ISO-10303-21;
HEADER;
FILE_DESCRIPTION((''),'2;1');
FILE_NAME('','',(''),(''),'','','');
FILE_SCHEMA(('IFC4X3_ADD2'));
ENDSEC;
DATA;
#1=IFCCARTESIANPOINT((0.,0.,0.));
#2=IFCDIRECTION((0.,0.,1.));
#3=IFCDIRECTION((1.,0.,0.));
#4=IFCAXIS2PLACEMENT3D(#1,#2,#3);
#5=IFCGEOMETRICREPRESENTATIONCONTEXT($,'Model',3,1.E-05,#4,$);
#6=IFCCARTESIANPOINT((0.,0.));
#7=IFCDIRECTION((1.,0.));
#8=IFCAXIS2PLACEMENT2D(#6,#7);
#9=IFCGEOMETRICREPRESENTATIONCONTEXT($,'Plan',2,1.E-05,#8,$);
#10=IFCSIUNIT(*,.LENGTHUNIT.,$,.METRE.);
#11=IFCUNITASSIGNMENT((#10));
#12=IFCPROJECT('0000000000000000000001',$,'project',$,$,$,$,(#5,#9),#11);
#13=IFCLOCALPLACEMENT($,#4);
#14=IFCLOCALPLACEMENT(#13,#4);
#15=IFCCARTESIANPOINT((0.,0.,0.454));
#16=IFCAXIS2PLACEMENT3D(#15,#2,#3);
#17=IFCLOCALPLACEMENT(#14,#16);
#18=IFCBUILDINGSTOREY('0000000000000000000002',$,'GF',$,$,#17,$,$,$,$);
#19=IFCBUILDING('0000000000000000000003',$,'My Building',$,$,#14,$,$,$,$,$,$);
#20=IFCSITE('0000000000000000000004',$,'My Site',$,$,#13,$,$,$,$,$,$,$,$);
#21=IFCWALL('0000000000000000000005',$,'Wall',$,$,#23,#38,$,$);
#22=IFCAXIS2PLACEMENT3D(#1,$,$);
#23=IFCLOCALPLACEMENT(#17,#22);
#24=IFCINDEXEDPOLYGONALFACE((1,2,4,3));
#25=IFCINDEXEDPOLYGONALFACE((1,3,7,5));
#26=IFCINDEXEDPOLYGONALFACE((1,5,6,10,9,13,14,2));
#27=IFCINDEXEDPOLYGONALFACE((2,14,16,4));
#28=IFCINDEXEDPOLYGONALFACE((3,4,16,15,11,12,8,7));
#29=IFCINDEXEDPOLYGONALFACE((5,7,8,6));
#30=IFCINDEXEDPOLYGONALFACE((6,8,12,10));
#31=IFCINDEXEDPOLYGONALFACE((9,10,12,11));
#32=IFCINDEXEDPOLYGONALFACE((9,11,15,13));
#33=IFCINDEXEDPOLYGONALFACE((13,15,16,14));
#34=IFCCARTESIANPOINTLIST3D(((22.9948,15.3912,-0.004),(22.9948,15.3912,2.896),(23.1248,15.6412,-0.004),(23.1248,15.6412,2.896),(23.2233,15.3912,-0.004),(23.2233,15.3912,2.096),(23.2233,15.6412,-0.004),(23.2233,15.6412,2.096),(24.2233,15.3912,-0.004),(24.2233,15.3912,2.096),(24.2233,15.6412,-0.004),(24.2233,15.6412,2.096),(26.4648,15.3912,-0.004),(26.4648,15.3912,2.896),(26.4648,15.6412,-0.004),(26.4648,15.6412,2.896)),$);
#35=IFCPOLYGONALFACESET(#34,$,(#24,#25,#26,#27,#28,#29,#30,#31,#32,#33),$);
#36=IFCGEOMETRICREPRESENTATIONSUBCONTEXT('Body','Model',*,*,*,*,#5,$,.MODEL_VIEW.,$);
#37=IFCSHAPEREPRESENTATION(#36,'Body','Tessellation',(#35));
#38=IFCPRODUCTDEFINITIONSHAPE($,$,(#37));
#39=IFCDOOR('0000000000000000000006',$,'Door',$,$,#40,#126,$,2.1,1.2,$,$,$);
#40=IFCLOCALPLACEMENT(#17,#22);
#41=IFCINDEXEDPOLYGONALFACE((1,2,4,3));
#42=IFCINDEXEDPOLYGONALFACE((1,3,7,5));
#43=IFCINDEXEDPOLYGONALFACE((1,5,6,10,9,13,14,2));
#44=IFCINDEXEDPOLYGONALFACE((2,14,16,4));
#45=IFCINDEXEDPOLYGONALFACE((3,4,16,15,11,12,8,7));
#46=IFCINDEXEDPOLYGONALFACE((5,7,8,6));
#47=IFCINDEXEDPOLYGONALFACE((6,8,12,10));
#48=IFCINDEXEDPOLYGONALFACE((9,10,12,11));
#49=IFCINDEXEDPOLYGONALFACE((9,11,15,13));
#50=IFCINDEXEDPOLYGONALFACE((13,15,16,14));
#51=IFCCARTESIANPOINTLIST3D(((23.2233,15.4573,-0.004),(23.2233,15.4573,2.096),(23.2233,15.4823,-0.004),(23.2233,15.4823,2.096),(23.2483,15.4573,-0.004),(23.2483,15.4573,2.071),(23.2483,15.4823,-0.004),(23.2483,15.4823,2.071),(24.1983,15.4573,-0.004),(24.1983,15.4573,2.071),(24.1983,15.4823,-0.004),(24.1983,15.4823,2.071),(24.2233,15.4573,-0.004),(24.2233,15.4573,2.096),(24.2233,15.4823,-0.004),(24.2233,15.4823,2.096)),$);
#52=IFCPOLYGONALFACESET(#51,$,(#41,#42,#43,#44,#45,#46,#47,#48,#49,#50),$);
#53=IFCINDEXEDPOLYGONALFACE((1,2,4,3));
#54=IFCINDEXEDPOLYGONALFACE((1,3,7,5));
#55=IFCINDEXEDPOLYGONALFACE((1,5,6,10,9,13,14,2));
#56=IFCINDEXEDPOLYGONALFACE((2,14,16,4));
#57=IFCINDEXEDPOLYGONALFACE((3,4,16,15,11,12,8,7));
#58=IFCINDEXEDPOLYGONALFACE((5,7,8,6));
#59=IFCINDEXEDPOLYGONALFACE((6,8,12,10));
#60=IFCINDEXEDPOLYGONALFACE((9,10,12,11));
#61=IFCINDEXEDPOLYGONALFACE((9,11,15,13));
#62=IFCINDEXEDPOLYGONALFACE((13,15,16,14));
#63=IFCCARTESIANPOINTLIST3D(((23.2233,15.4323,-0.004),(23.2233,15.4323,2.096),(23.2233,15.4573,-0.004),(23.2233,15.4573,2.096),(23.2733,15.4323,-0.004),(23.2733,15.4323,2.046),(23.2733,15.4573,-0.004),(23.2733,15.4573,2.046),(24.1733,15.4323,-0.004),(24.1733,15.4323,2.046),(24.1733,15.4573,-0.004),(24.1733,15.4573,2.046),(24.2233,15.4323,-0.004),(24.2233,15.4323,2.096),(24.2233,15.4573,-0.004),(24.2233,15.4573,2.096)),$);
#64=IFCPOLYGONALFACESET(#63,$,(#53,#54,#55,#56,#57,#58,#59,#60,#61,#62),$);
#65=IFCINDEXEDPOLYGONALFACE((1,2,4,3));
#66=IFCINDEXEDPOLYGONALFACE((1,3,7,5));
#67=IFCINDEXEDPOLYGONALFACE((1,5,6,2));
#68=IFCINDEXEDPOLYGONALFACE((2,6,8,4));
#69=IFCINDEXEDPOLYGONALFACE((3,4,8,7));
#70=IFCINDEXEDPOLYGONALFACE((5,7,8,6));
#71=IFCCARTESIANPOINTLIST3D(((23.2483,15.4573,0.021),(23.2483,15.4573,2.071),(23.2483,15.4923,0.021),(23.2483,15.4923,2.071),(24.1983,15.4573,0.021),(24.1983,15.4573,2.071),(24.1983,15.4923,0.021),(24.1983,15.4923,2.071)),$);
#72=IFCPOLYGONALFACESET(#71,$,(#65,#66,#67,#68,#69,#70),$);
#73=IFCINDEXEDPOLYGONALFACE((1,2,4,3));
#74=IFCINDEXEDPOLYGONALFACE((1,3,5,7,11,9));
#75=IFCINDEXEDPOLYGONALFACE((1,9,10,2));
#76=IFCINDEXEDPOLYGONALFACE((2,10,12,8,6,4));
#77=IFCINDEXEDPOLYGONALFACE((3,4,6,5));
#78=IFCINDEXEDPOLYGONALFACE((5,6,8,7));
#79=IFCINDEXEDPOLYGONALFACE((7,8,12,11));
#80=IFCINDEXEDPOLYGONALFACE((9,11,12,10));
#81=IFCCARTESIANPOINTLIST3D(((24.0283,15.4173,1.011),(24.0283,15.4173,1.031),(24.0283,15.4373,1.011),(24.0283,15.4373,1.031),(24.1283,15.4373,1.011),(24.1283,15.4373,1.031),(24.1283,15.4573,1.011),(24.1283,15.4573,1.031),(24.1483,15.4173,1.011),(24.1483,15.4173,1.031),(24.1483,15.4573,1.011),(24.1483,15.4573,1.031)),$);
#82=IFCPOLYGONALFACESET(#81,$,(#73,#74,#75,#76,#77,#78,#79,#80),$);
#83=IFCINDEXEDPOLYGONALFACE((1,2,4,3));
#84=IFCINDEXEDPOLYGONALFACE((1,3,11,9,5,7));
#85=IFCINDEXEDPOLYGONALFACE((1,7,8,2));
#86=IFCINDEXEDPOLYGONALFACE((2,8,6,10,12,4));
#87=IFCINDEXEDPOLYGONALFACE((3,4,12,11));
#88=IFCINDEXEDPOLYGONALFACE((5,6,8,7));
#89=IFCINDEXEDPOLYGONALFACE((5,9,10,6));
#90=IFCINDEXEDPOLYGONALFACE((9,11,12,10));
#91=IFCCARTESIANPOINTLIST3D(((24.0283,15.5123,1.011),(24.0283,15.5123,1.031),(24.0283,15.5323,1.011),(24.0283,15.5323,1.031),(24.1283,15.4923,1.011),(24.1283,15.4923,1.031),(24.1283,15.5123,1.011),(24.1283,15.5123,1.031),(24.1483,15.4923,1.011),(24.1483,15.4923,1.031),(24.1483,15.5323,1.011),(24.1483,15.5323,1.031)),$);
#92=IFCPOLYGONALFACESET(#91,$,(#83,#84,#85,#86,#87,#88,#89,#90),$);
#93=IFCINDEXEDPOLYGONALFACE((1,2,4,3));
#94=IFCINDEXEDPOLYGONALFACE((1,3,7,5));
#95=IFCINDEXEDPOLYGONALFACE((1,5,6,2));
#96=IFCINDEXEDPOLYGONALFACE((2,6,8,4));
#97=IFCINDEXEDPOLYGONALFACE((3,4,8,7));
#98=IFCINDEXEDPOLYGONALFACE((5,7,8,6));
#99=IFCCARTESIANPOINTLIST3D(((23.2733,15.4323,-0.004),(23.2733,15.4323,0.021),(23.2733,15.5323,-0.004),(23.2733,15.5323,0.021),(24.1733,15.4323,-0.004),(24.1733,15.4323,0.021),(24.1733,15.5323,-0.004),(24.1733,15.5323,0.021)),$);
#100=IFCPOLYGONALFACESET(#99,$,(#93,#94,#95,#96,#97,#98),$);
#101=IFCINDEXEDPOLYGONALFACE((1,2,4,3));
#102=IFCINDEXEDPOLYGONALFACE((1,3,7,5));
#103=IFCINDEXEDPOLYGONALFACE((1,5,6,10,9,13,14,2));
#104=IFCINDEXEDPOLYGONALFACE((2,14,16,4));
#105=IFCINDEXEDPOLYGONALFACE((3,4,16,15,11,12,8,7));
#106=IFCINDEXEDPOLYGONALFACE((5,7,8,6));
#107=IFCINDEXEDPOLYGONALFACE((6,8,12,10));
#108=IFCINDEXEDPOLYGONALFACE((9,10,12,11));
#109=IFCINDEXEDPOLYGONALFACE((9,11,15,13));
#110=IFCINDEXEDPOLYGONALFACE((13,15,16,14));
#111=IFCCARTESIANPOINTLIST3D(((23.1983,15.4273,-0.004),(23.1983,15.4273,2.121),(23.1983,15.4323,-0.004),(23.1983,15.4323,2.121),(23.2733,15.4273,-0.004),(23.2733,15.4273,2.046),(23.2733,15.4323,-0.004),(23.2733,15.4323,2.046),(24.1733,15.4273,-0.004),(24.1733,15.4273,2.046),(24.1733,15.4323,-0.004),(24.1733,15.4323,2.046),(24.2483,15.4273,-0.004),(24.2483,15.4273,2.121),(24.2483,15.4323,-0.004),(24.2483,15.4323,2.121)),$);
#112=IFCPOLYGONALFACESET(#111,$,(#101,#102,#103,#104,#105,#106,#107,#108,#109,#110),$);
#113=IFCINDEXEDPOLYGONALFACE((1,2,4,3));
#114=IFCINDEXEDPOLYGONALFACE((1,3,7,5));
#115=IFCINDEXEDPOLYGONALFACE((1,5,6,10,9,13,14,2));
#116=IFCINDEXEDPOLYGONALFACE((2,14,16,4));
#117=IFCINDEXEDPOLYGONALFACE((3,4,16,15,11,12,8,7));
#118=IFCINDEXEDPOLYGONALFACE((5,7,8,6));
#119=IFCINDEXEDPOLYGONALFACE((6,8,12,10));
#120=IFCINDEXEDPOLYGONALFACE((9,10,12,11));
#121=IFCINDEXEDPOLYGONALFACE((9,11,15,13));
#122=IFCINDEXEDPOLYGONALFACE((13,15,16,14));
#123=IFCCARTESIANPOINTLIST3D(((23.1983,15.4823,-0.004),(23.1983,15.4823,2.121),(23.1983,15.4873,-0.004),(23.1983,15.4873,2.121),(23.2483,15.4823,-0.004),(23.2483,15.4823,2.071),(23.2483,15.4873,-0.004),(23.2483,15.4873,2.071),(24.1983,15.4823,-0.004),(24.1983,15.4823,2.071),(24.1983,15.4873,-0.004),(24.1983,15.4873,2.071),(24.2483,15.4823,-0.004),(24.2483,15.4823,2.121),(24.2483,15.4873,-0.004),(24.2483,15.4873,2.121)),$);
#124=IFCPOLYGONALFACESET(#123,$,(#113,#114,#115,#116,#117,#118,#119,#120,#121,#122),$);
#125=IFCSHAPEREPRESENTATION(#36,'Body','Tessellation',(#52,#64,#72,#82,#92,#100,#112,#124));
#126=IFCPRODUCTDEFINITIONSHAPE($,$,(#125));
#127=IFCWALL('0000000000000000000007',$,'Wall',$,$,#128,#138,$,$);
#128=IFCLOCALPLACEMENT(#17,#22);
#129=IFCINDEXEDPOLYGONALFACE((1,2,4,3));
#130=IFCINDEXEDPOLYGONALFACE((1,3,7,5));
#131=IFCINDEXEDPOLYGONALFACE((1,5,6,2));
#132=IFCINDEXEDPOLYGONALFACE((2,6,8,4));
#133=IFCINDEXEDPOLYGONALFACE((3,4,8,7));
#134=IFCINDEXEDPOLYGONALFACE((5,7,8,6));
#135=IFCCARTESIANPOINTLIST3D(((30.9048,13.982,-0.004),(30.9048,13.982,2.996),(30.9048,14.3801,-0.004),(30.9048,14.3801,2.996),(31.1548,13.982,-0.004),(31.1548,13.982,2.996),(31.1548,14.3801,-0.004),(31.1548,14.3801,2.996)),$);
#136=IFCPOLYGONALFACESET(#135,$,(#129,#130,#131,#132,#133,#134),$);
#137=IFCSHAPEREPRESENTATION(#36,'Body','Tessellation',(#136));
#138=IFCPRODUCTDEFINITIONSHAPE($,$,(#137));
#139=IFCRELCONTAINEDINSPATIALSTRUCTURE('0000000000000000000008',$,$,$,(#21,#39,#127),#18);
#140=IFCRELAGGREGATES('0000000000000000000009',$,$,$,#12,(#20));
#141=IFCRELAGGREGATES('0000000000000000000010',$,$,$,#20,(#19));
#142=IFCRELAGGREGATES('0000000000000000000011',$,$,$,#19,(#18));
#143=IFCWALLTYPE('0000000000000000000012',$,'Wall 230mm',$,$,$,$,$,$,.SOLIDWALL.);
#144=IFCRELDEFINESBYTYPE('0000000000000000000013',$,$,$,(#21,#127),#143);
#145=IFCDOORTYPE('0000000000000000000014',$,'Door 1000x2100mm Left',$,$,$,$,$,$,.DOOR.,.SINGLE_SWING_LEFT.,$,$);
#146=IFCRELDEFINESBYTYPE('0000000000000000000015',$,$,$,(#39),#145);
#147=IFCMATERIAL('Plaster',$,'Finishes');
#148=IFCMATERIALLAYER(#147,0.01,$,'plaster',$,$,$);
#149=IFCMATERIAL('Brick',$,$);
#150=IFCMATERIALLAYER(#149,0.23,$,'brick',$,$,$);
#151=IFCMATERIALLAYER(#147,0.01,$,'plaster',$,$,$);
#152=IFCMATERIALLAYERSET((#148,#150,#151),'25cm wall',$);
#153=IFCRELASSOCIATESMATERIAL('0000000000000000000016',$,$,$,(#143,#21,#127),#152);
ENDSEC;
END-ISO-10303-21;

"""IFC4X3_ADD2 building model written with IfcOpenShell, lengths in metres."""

from ifc_helpers import new_model, entity, si_unit, frame, origin_with_axes, origin_2d_with_axis, place, context, subcontext, project, spatial, line, indexed_curve, outline, extrude, shape, source, transform, mapped, material, layer, layer_set, layer_usage, type_object, type_shapes, element, fill, save


model = new_model("IFC4X3_ADD2")

# Units and contexts
model_context = context("Model", 3, precision=1e-05, world=origin_with_axes())
plan_context = context("Plan", 2, precision=1e-05, world=origin_2d_with_axis())
body_context_1 = subcontext(model_context, "Body", "Model", "MODEL_VIEW")
body_context_2 = subcontext(plan_context, "Body", "Plan", "PLAN_VIEW")
ifc_project = project(units=[si_unit("LENGTHUNIT", "METRE")], contexts=[model_context, plan_context])

# Site, building, storey
site_placement = place(None, origin_with_axes())
site = spatial("IfcSite", under=ifc_project, at=site_placement, Name="My Site")
building_placement = place(site_placement, origin_with_axes())
building = spatial("IfcBuilding", under=site, at=building_placement, Name="My Building")
storey_placement = place(building_placement, frame((0.0, 0.0, 0.454), z_axis=(0.0, 0.0, 1.0), x_axis=(1.0, 0.0, 0.0)))
storey = spatial("IfcBuildingStorey", under=building, at=storey_placement, Name="GF")

# Shared definitions
ifc_material_1 = material(Name="Plaster", Category="Finishes")
ifc_layer_1 = layer(ifc_material_1, 0.01, Name="plaster")
ifc_material_2 = material(Name="Brick")
ifc_layer_2 = layer(ifc_material_2, 0.23, Name="brick")
ifc_layer_3 = layer(ifc_material_1, 0.01, Name="plaster")
ifc_layer_set_1 = layer_set([ifc_layer_1, ifc_layer_2, ifc_layer_3], Name="25cm wall")
wall_type_1 = type_object("IfcWallType", Name="Wall 230mm", PredefinedType="SOLIDWALL", material=ifc_layer_set_1)

# Wall, opening, door
ifc_layer_usage_1 = layer_usage(ifc_layer_set_1, "AXIS2", "POSITIVE", 0.0)
wall_1_placement = place(storey_placement, frame((26.4648, 15.6412, -0.004), z_axis=(0.0, 0.0, 1.0), x_axis=(-1.0, 0.0, 0.0)))
wall_1 = element("IfcWall", 1, at=wall_1_placement, inside=storey, type_object=wall_type_1, material=ifc_layer_usage_1, Name="Wall", context=body_context_1, shape_type="SweptSolid", body=[
    extrude(outline(indexed_curve([(0.0, 0.0), (0.0, 0.25), (3.47, 0.25), (3.34, 0.0)], segments=[line(1, 2, 3, 4, 1)])), origin_with_axes(), (0.0, 0.0, 1.0), 2.9),
])
shared_shape_1 = source(origin_with_axes(), body_context_1, "Body", "SweptSolid", [
    extrude(outline(indexed_curve([(0.0, 0.0), (1.0, 0.0), (1.0, 2.1), (0.0, 2.1)], segments=[line(1, 2, 3, 4, 1)])), frame((0.0, -0.6, 0.0), z_axis=(0.0, -1.0, 0.0), x_axis=(1.0, 0.0, 0.0)), (0.0, 0.0, -1.0), 1.2),
])
opening_1_placement = place(wall_1_placement, frame((3.2415, 0.209, 0.0), z_axis=(0.0, 0.0, 1.0), x_axis=(-1.0, 0.0, 0.0)))
opening_1 = element("IfcOpeningElement", 2, at=opening_1_placement, cuts=wall_1, PredefinedType="OPENING", context=body_context_1, shape_type="MappedRepresentation", body=[
    mapped(shared_shape_1, transform((0.0, 0.0, 0.0), x_axis=(1.0, 0.0, 0.0), y_axis=(0.0, 1.0, 0.0), z_axis=(0.0, 0.0, 1.0), scale=1.0)),
])
door_type_1 = type_object("IfcDoorType", Name="Door 1000x2100mm Left", OperationType="SINGLE_SWING_LEFT", PredefinedType="DOOR")
shared_shape_2 = source(origin_with_axes(), body_context_1, "Body", "SweptSolid", [
    extrude(outline(indexed_curve([(0.0, 0.0), (0.0, 2.1), (1.0, 2.1), (1.0, 0.0), (0.975, 0.0), (0.975, 2.075), (0.025, 2.075), (0.025, 0.0)], segments=[line(1, 2, 3, 4, 5, 6, 7, 8, 1)])), frame((0.0, 0.025, 0.0), z_axis=(0.0, -1.0, 0.0), x_axis=(1.0, 0.0, 0.0)), (0.0, 0.0, -1.0), 0.025),
    extrude(outline(indexed_curve([(0.0, 0.0), (0.0, 2.1), (1.0, 2.1), (1.0, 0.0), (0.95, 0.0), (0.95, 2.05), (0.05, 2.05), (0.05, 0.0)], segments=[line(1, 2, 3, 4, 5, 6, 7, 8, 1)])), frame((0.0, 0.0, 0.0), z_axis=(0.0, -1.0, 0.0), x_axis=(1.0, 0.0, 0.0)), (0.0, 0.0, -1.0), 0.025),
    extrude(outline(indexed_curve([(0.0, 0.0), (0.95, 0.0), (0.95, 0.035), (0.0, 0.035)], segments=[line(1, 2, 3, 4, 1)])), frame((0.025, 0.025, 0.025), z_axis=(0.0, 0.0, 1.0), x_axis=(1.0, 0.0, 0.0)), (0.0, 0.0, 1.0), 2.05),
    extrude(outline(indexed_curve([(0.0, 0.0), (0.0, -0.04), (-0.12, -0.04), (-0.12, -0.02), (-0.02, -0.02), (-0.02, 0.0)], segments=[line(1, 2, 3, 4, 5, 6, 1)])), frame((0.925, 0.025, 1.015), z_axis=(0.0, 0.0, 1.0), x_axis=(1.0, 0.0, 0.0)), (0.0, 0.0, 1.0), 0.02),
    extrude(outline(indexed_curve([(0.0, 0.0), (0.0, 0.04), (-0.12, 0.04), (-0.12, 0.02), (-0.02, 0.02), (-0.02, 0.0)], segments=[line(1, 2, 3, 4, 5, 6, 1)])), frame((0.925, 0.06, 1.015), z_axis=(0.0, 0.0, 1.0), x_axis=(1.0, 0.0, 0.0)), (0.0, 0.0, 1.0), 0.02),
    extrude(outline(indexed_curve([(0.0, 0.0), (0.9, 0.0), (0.9, 0.1), (0.0, 0.1)], segments=[line(1, 2, 3, 4, 1)])), frame((0.05, 0.0, 0.0), z_axis=(0.0, 0.0, 1.0), x_axis=(1.0, 0.0, 0.0)), (0.0, 0.0, 1.0), 0.025),
    extrude(outline(indexed_curve([(0.0, 0.0), (0.0, 2.125), (1.05, 2.125), (1.05, 0.0), (0.975, 0.0), (0.975, 2.05), (0.075, 2.05), (0.075, 0.0)], segments=[line(1, 2, 3, 4, 5, 6, 7, 8, 1)])), frame((-0.025, -0.005, 0.0), z_axis=(0.0, -1.0, 0.0), x_axis=(1.0, 0.0, 0.0)), (0.0, 0.0, -1.0), 0.005),
    extrude(outline(indexed_curve([(0.0, 0.0), (0.0, 2.125), (1.05, 2.125), (1.05, 0.0), (1.0, 0.0), (1.0, 2.075), (0.05, 2.075), (0.05, 0.0)], segments=[line(1, 2, 3, 4, 5, 6, 7, 8, 1)])), frame((-0.025, 0.05, 0.0), z_axis=(0.0, -1.0, 0.0), x_axis=(1.0, 0.0, 0.0)), (0.0, 0.0, -1.0), 0.005),
])
shared_shape_3 = source(origin_with_axes(), body_context_2, "Body", "Curve2D", [
    entity("IfcIndexedPolyCurve", entity("IfcCartesianPointList2D", [[0.0, 0.0], [0.0, 0.05], [0.025, 0.05], [0.025, 0.025], [0.05, 0.025], [0.05, 0.0]]), [entity("IfcLineIndex", [1, 2, 3, 4, 5, 6, 1])]),
    entity("IfcIndexedPolyCurve", entity("IfcCartesianPointList2D", [[1.0, 0.0], [1.0, 0.05], [0.975, 0.05], [0.975, 0.025], [0.95, 0.025], [0.95, 0.0]]), [entity("IfcLineIndex", [1, 2, 3, 4, 5, 6, 1])]),
    entity("IfcTrimmedCurve", entity("IfcEllipse", entity("IfcAxis2Placement2D", entity("IfcCartesianPoint", [0.06, 0.05]), entity("IfcDirection", [1.0, 0.0])), 0.915, 0.95), [entity("IfcCartesianPoint", [0.975, 0.05])], [entity("IfcCartesianPoint", [0.06, 1.0])], True, "CARTESIAN"),
    entity("IfcIndexedPolyCurve", entity("IfcCartesianPointList2D", [[0.025, 0.05], [0.06, 0.05], [0.06, 1.0], [0.025, 1.0]]), [entity("IfcLineIndex", [1, 2, 3, 4, 1])]),
])
type_shapes(door_type_1, [shared_shape_2, shared_shape_3])
door_1_placement = place(opening_1_placement, frame((0.0, 0.0, 0.0), z_axis=(0.0, 0.0, 1.0), x_axis=(1.0, 0.0, 0.0)))
door_1 = element("IfcDoor", 3, at=door_1_placement, inside=storey, type_object=door_type_1, Name="Door", OverallHeight=2.1, OverallWidth=1.2, shapes=[
    shape(body_context_1, "Body", "MappedRepresentation", [mapped(shared_shape_2, transform((0.0, 0.0, 0.0), x_axis=(1.0, 0.0, 0.0), y_axis=(0.0, 1.0, 0.0), z_axis=(0.0, 0.0, 1.0), scale=1.0))]),
    shape(body_context_2, "Body", "MappedRepresentation", [mapped(shared_shape_3, transform((0.0, 0.0, 0.0), x_axis=(1.0, 0.0, 0.0), y_axis=(0.0, 1.0, 0.0), z_axis=(0.0, 0.0, 1.0), scale=1.0))]),
])
fill(opening_1, door_1)

# Wall
ifc_layer_usage_2 = layer_usage(ifc_layer_set_1, "AXIS2", "POSITIVE", 0.0)
wall_2_placement = place(storey_placement, frame((31.1548, 13.982, -0.004), z_axis=(0.0, 0.0, 1.0), x_axis=(0.000001, 1.0, 0.0)))
element("IfcWall", 4, at=wall_2_placement, inside=storey, type_object=wall_type_1, material=ifc_layer_usage_2, Name="Wall", context=body_context_1, shape_type="SweptSolid", body=[
    extrude(outline(indexed_curve([(0.0, 0.0), (0.0, 0.25), (0.3981, 0.25), (0.3981, 0.0)], segments=[line(1, 2, 3, 4, 1)])), origin_with_axes(), (0.0, 0.0, 1.0), 3.0),
])

save(model, "model.ifc")
